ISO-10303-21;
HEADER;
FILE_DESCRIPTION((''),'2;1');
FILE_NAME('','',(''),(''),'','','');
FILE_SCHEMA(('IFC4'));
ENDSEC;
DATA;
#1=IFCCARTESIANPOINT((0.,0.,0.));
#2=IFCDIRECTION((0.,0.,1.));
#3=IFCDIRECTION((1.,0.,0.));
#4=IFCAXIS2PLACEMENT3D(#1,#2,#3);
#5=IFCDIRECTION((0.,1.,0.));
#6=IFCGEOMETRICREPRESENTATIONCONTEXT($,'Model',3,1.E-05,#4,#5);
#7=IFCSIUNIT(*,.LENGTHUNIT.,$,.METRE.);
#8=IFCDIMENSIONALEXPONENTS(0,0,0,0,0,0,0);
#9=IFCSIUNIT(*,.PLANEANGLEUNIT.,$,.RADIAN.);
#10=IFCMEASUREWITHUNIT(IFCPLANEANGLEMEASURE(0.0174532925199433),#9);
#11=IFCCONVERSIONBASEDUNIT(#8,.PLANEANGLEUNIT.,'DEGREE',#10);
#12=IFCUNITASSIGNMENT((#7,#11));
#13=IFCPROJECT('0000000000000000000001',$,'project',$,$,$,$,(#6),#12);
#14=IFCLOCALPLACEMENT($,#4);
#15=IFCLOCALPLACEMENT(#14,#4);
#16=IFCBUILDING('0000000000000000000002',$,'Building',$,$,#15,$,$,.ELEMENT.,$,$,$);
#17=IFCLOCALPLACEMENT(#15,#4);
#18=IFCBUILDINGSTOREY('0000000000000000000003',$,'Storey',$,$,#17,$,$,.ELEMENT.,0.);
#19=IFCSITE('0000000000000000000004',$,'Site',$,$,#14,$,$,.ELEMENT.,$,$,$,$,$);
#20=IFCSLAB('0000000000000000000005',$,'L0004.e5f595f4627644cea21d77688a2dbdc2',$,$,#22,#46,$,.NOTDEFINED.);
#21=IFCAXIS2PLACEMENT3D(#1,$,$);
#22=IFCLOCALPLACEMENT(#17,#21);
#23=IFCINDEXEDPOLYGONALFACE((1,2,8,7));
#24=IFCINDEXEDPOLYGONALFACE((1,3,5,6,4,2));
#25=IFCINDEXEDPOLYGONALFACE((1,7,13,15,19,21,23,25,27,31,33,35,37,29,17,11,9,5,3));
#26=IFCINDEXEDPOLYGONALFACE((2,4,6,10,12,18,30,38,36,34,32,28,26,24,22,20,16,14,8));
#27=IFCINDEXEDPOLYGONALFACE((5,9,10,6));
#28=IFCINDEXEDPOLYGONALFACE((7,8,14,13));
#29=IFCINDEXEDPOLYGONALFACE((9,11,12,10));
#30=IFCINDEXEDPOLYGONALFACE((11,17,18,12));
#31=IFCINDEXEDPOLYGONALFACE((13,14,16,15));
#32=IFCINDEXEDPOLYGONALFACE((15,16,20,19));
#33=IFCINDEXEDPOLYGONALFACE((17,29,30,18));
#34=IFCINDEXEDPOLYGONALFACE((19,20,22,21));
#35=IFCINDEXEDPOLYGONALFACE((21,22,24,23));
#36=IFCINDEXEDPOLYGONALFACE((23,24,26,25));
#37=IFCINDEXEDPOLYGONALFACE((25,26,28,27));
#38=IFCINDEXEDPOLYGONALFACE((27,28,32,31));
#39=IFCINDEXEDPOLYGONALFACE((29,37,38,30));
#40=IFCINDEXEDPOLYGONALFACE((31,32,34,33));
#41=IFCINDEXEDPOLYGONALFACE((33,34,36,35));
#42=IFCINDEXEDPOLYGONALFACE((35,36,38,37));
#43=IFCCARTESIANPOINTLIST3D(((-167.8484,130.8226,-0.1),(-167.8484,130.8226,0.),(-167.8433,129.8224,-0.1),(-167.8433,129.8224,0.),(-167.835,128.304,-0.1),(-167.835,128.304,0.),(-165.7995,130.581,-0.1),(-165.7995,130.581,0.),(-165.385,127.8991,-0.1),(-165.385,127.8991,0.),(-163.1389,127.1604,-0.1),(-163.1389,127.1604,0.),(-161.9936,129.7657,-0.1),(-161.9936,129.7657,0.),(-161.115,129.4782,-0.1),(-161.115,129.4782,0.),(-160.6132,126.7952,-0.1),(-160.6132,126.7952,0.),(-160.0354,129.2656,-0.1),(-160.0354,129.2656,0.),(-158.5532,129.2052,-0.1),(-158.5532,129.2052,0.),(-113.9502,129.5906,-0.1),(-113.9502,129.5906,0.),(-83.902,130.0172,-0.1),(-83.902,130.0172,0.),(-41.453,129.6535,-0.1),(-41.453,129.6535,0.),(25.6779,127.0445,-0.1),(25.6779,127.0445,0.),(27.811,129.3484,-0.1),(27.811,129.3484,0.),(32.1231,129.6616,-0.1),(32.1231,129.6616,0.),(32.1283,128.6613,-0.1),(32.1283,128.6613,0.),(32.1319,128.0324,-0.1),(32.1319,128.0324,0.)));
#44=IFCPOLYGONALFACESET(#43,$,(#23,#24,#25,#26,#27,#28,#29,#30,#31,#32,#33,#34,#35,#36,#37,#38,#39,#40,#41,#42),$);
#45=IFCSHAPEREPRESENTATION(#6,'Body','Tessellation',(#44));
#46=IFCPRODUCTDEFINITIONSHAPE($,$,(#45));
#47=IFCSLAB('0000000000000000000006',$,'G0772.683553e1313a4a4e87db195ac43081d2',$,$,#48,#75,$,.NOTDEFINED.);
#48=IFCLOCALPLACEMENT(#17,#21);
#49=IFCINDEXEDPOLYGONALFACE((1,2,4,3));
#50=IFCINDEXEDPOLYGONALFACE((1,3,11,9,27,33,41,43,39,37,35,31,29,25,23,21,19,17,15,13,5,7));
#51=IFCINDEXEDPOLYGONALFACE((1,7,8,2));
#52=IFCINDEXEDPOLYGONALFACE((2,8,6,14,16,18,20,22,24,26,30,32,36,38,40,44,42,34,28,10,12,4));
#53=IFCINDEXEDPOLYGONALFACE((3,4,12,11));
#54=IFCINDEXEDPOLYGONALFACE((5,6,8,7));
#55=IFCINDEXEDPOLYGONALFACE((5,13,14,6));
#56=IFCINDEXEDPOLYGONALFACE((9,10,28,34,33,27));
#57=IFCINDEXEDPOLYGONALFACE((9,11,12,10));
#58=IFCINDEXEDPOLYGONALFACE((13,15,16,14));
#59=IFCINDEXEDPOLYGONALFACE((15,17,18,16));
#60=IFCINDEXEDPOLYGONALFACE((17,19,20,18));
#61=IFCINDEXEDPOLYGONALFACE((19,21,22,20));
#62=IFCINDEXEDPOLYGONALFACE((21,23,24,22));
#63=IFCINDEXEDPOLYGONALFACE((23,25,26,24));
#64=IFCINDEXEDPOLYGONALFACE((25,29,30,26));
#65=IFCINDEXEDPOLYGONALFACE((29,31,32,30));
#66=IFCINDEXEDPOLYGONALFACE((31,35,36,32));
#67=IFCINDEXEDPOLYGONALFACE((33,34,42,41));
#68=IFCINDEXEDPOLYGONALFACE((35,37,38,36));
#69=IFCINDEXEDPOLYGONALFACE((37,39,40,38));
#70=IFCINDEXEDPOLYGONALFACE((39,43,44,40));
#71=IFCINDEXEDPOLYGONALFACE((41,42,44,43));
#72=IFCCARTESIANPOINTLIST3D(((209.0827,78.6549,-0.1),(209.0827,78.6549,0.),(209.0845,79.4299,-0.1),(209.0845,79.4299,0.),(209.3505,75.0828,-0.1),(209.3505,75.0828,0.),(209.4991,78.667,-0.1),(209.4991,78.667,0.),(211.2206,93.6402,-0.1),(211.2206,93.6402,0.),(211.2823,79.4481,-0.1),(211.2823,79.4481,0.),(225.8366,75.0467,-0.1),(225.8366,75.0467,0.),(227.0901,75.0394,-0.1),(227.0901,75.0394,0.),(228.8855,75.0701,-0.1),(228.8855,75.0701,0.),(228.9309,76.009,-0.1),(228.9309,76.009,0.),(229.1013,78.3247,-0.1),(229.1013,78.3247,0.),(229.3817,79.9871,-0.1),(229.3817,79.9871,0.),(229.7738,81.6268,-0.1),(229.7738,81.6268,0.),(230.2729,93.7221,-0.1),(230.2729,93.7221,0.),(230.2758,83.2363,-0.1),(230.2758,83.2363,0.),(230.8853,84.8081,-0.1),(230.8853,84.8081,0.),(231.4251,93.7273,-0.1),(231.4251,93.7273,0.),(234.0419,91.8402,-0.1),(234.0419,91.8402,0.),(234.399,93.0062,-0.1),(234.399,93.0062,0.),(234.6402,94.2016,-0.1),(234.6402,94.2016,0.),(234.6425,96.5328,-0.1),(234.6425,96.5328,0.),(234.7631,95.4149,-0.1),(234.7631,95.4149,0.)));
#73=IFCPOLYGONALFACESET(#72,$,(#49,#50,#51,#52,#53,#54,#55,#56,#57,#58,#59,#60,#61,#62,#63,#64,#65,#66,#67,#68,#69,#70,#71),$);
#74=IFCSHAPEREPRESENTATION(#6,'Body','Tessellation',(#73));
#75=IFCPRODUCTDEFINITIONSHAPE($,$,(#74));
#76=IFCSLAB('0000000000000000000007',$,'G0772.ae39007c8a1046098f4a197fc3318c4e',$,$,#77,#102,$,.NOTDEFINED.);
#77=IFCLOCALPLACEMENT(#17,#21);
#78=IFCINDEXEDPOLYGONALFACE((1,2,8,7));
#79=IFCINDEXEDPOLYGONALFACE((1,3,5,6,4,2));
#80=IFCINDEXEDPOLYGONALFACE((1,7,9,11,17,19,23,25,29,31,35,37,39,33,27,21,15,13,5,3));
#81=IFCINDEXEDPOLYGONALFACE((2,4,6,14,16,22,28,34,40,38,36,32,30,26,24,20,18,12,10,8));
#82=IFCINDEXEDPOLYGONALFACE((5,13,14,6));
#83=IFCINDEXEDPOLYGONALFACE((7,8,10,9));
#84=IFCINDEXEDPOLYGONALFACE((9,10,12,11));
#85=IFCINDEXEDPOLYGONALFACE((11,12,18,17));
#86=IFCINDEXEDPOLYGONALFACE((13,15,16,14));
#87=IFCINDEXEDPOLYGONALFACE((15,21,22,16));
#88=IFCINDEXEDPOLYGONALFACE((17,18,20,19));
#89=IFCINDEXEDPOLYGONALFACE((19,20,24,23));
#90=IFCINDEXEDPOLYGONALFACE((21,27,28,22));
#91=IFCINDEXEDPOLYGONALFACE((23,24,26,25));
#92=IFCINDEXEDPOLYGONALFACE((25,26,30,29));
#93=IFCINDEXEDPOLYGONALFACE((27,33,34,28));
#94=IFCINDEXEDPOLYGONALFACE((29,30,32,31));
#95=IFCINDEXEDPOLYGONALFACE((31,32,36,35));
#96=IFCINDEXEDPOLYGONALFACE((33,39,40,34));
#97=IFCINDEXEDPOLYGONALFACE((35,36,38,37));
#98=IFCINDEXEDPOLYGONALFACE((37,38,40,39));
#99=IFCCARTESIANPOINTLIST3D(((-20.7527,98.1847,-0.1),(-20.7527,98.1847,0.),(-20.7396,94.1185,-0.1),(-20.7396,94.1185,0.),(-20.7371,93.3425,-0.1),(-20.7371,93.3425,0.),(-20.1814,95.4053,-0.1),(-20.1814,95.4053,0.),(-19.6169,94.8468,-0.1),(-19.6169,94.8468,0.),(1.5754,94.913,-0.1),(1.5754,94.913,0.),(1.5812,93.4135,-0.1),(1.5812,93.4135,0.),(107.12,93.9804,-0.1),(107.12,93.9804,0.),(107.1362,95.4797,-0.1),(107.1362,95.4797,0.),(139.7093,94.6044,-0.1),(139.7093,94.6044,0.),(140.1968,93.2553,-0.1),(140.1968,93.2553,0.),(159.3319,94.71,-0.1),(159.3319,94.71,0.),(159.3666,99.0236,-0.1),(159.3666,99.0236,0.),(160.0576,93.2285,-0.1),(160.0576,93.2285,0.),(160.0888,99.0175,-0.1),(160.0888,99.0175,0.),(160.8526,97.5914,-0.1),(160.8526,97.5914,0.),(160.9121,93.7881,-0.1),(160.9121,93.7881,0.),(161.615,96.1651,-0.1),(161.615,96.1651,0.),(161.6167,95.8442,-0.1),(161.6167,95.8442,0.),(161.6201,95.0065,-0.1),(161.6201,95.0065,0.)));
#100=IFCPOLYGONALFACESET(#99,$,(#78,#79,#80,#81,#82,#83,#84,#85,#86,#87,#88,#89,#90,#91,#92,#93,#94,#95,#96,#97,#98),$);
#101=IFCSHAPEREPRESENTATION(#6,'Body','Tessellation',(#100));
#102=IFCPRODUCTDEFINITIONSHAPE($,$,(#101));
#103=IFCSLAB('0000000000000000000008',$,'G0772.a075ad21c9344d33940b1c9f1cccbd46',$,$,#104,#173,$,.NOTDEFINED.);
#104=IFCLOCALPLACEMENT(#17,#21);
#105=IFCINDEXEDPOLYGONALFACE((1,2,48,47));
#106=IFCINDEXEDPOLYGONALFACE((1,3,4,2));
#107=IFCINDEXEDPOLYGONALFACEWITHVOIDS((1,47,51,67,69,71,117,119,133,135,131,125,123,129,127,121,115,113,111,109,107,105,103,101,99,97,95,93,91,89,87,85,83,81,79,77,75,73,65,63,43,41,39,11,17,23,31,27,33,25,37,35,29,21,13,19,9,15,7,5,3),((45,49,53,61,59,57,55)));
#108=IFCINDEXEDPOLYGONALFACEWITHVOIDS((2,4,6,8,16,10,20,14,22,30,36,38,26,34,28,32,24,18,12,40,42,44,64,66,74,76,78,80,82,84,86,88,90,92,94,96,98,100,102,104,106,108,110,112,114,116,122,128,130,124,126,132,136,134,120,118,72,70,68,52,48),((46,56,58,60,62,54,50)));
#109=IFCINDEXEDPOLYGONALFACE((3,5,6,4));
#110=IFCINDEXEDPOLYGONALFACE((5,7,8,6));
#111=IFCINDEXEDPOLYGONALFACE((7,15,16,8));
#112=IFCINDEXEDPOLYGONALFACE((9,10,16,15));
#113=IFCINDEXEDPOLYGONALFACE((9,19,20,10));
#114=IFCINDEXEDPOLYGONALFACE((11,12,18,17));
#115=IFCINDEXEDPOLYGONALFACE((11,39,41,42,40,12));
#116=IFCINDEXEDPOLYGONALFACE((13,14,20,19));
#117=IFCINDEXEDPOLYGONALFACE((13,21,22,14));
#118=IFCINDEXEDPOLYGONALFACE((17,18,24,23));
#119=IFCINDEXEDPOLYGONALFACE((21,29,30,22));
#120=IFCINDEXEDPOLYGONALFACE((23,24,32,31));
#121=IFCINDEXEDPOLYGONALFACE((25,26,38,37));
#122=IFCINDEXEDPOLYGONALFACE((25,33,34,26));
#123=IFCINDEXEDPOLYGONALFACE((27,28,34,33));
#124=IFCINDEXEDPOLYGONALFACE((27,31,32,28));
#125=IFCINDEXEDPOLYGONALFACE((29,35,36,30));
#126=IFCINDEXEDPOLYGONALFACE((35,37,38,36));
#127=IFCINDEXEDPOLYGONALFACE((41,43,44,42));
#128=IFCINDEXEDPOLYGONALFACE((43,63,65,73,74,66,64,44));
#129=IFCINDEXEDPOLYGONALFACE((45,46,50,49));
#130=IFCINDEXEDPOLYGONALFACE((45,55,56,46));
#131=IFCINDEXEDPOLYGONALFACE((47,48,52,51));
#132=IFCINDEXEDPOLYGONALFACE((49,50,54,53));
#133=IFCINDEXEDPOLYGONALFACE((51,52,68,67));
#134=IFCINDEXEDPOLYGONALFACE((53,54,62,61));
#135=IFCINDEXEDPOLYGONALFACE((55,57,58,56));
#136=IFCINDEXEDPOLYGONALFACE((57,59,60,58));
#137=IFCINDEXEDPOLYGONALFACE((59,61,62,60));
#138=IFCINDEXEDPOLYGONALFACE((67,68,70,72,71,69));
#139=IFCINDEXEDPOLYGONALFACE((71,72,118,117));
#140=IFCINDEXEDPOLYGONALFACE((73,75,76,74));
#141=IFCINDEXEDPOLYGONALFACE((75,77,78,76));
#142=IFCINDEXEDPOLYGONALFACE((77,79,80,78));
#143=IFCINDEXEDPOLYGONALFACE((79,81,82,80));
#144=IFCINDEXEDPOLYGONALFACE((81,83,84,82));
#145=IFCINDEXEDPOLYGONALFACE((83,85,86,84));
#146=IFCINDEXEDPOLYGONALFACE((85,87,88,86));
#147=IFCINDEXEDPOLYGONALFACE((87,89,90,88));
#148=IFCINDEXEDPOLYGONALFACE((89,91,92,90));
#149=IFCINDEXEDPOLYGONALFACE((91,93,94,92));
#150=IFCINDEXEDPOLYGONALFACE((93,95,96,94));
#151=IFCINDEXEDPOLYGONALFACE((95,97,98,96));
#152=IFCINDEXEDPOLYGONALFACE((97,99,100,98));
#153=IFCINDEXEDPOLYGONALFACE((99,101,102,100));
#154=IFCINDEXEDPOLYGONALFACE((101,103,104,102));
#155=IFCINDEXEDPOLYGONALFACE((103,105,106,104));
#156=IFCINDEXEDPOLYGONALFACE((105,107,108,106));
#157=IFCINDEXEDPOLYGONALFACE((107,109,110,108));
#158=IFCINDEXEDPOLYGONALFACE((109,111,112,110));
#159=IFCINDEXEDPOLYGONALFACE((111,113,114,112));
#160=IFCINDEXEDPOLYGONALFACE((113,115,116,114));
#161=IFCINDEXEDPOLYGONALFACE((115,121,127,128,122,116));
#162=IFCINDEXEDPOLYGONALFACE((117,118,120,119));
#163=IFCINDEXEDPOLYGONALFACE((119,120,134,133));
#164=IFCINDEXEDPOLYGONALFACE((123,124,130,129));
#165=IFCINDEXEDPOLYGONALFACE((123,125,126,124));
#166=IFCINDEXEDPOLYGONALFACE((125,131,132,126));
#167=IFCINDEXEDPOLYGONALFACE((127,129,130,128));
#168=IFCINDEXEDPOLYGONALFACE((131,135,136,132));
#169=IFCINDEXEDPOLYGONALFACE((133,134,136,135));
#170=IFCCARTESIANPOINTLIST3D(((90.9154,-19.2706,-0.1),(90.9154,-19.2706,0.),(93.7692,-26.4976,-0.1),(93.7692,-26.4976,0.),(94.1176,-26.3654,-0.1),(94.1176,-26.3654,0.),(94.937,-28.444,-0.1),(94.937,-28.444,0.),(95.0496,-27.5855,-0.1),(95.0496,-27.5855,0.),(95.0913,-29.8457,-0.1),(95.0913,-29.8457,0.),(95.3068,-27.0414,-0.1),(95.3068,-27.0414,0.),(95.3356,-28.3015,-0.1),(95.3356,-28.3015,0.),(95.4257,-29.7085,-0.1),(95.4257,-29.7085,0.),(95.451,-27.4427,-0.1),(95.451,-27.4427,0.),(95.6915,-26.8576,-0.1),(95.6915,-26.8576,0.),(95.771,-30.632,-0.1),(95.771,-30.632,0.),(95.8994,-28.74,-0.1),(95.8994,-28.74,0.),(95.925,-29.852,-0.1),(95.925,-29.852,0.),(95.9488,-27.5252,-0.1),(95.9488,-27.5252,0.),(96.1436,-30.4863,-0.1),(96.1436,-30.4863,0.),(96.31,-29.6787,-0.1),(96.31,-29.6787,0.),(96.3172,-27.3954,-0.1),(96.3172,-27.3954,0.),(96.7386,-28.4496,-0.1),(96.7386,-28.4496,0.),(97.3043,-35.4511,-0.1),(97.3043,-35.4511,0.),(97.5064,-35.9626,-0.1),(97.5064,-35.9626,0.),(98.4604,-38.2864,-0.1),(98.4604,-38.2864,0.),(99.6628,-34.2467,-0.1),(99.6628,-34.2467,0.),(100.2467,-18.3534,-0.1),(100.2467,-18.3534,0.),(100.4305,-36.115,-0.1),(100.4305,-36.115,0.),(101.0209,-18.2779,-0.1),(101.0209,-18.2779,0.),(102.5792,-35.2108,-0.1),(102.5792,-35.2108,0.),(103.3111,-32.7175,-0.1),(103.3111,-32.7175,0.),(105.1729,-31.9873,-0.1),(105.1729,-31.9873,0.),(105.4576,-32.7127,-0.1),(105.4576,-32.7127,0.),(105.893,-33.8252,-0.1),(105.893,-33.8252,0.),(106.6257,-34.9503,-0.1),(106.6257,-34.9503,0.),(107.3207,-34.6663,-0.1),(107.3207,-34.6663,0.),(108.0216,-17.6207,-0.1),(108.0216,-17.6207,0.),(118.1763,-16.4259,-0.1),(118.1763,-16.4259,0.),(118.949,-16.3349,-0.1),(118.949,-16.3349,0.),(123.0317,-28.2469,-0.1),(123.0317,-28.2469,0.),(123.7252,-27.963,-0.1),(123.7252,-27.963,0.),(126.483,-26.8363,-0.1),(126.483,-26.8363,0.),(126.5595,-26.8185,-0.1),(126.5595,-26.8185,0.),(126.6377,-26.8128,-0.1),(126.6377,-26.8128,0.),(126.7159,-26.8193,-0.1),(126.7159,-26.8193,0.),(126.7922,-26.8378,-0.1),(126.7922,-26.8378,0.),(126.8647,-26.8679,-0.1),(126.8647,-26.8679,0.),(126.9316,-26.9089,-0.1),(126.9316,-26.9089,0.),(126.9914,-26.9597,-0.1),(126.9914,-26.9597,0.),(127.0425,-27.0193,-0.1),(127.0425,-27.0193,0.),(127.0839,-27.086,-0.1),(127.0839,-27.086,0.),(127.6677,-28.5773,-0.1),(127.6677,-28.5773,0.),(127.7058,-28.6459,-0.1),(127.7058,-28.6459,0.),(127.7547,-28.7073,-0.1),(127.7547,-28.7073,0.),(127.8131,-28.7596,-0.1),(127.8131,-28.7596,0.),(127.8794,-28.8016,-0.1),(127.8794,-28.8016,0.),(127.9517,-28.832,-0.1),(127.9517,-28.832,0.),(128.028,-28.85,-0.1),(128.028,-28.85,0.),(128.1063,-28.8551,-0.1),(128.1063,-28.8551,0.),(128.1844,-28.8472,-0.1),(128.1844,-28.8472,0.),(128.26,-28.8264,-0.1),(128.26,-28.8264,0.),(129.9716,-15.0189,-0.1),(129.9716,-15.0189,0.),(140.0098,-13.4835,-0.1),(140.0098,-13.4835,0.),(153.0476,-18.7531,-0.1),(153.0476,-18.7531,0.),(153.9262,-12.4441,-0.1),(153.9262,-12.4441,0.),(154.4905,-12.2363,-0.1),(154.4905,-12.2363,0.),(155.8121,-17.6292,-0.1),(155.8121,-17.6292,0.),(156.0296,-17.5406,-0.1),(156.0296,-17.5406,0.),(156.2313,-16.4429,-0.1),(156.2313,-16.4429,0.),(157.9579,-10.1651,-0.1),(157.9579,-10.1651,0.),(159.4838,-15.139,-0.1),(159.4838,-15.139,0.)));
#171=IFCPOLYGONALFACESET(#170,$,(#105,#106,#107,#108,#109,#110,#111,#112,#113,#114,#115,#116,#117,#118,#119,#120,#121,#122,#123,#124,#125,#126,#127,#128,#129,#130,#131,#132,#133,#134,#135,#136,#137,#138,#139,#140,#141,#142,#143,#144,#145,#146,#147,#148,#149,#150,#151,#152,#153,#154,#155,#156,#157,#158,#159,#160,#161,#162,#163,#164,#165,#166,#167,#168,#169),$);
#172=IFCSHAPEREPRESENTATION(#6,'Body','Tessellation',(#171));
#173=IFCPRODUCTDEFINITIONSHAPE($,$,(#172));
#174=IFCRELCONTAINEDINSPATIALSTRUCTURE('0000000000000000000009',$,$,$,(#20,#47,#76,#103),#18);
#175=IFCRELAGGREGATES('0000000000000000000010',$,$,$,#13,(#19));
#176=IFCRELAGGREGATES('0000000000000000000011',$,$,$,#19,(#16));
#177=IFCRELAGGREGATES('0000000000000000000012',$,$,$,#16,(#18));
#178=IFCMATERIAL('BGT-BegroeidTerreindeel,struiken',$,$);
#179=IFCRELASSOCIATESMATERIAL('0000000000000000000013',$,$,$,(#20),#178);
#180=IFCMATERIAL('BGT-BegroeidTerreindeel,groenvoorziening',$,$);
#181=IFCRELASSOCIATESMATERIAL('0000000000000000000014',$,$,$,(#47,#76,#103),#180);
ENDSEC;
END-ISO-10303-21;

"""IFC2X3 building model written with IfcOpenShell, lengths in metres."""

from ifc_helpers import new_model, entity, si_unit, converted_unit, direction, frame, origin_with_axes, place, context, project, spatial, polyline, outline, extrude, material, element, save


model = new_model("IFC2X3")

# Units and contexts
model_context = context("Model", 3, precision=1e-05, world=origin_with_axes(), true_north=direction((0.0, 1.0, 0.0)))
ifc_project = project(units=[si_unit("LENGTHUNIT", "METRE"), converted_unit("PLANEANGLEUNIT", "DEGREE", entity("IfcPlaneAngleMeasure", 0.0174532925199433), si_unit("PLANEANGLEUNIT", "RADIAN"), dimensions=[0, 0, 0, 0, 0, 0, 0])], contexts=[model_context])

# Site, building, storey
site_placement = place(None, origin_with_axes())
site = spatial("IfcSite", under=ifc_project, at=site_placement, Name="Site", CompositionType="ELEMENT")
building_placement = place(site_placement, origin_with_axes())
building = spatial("IfcBuilding", under=site, at=building_placement, Name="Building", CompositionType="ELEMENT")
storey_placement = place(building_placement, origin_with_axes())
storey = spatial("IfcBuildingStorey", under=building, at=storey_placement, Name="Storey", CompositionType="ELEMENT", Elevation=0.0)

# Slabs
ifc_material_1 = material(Name="BGT-BegroeidTerreindeel,struiken")
slab_1_placement = place(storey_placement, frame((0.0, 0.0, -0.1), z_axis=(0.0, 0.0, 1.0), x_axis=(1.0, 0.0, 0.0)))
element("IfcSlab", 1, at=slab_1_placement, inside=storey, material=ifc_material_1, Name="L0004.e5f595f4627644cea21d77688a2dbdc2", PredefinedType="NOTDEFINED", context=model_context, shape_type="SweptSolid", body=[
    extrude(outline(polyline([(27.811, 129.3484), (32.1231, 129.6616), (32.1283, 128.6613), (32.1319, 128.0324), (25.6779, 127.0445), (-160.6132, 126.7952), (-163.1389, 127.1604), (-165.385, 127.8991), (-167.835, 128.304), (-167.8433, 129.8224), (-167.8484, 130.8226), (-165.7995, 130.581), (-161.9936, 129.7657), (-161.115, 129.4782), (-160.0354, 129.2656), (-158.5532, 129.2052), (-113.9502, 129.5906), (-83.902, 130.0172), (-41.453, 129.6535), (27.811, 129.3484)])), origin_with_axes(), (0.0, 0.0, 1.0), 0.1),
])
ifc_material_2 = material(Name="BGT-BegroeidTerreindeel,groenvoorziening")
slab_2_placement = place(storey_placement, frame((0.0, 0.0, -0.1), z_axis=(0.0, 0.0, 1.0), x_axis=(1.0, 0.0, 0.0)))
element("IfcSlab", 2, at=slab_2_placement, inside=storey, material=ifc_material_2, Name="G0772.683553e1313a4a4e87db195ac43081d2", PredefinedType="NOTDEFINED", context=model_context, shape_type="SweptSolid", body=[
    extrude(outline(polyline([(234.6425, 96.5328), (234.7631, 95.4149), (234.6402, 94.2016), (234.399, 93.0062), (234.0419, 91.8402), (230.8853, 84.8081), (230.2758, 83.2363), (229.7738, 81.6268), (229.3817, 79.9871), (229.1013, 78.3247), (228.9309, 76.009), (228.8855, 75.0701), (227.0901, 75.0394), (225.8366, 75.0467), (209.3505, 75.0828), (209.4991, 78.667), (209.0827, 78.6549), (209.0845, 79.4299), (211.2823, 79.4481), (211.2206, 93.6402), (230.2729, 93.7221), (231.4251, 93.7273), (234.6425, 96.5328)])), origin_with_axes(), (0.0, 0.0, 1.0), 0.1),
])
slab_3_placement = place(storey_placement, frame((0.0, 0.0, -0.1), z_axis=(0.0, 0.0, 1.0), x_axis=(1.0, 0.0, 0.0)))
element("IfcSlab", 3, at=slab_3_placement, inside=storey, material=ifc_material_2, Name="G0772.ae39007c8a1046098f4a197fc3318c4e", PredefinedType="NOTDEFINED", context=model_context, shape_type="SweptSolid", body=[
    extrude(outline(polyline([(-20.7396, 94.1185), (-20.7527, 98.1847), (-20.1814, 95.4053), (-19.6169, 94.8468), (1.5754, 94.913), (107.1362, 95.4797), (139.7093, 94.6044), (159.3319, 94.71), (159.3666, 99.0236), (160.0888, 99.0175), (160.8526, 97.5914), (161.615, 96.1651), (161.6167, 95.8442), (161.6201, 95.0065), (160.9121, 93.7881), (160.0576, 93.2285), (140.1968, 93.2553), (107.12, 93.9804), (1.5812, 93.4135), (-20.7371, 93.3425), (-20.7396, 94.1185)])), origin_with_axes(), (0.0, 0.0, 1.0), 0.1),
])
slab_4_placement = place(storey_placement, frame((0.0, 0.0, -0.1), z_axis=(0.0, 0.0, 1.0), x_axis=(1.0, 0.0, 0.0)))
element("IfcSlab", 4, at=slab_4_placement, inside=storey, material=ifc_material_2, Name="G0772.a075ad21c9344d33940b1c9f1cccbd46", PredefinedType="NOTDEFINED", context=model_context, shape_type="SweptSolid", body=[
    extrude(outline(polyline([(140.0098, -13.4835), (157.9579, -10.1651), (159.4838, -15.139), (156.2313, -16.4429), (154.4905, -12.2363), (153.9262, -12.4441), (156.0296, -17.5406), (155.8121, -17.6292), (153.0476, -18.7531), (128.26, -28.8264), (128.1844, -28.8472), (128.1063, -28.8551), (128.028, -28.85), (127.9517, -28.832), (127.8794, -28.8016), (127.8131, -28.7596), (127.7547, -28.7073), (127.7058, -28.6459), (127.6677, -28.5773), (127.0839, -27.086), (127.0425, -27.0193), (126.9914, -26.9597), (126.9316, -26.9089), (126.8647, -26.8679), (126.7922, -26.8378), (126.7159, -26.8193), (126.6377, -26.8128), (126.5595, -26.8185), (126.483, -26.8363), (123.7252, -27.963), (123.0317, -28.2469), (107.3207, -34.6663), (106.6257, -34.9503), (98.4604, -38.2864), (97.5064, -35.9626), (97.3043, -35.4511), (95.0913, -29.8457), (95.4257, -29.7085), (95.771, -30.632), (96.1436, -30.4863), (95.925, -29.852), (96.31, -29.6787), (95.8994, -28.74), (96.7386, -28.4496), (96.3172, -27.3954), (95.9488, -27.5252), (95.6915, -26.8576), (95.3068, -27.0414), (95.451, -27.4427), (95.0496, -27.5855), (95.3356, -28.3015), (94.937, -28.444), (94.1176, -26.3654), (93.7692, -26.4976), (90.9154, -19.2706), (100.2467, -18.3534), (101.0209, -18.2779), (108.0216, -17.6207), (118.1763, -16.4259), (118.949, -16.3349), (129.9716, -15.0189), (140.0098, -13.4835)]), holes=[polyline([(99.6628, -34.2467), (100.4305, -36.115), (102.5792, -35.2108), (105.893, -33.8252), (105.4576, -32.7127), (105.1729, -31.9873), (103.3111, -32.7175), (99.6628, -34.2467)])]), origin_with_axes(), (0.0, 0.0, 1.0), 0.1),
])

save(model, "model.ifc")
